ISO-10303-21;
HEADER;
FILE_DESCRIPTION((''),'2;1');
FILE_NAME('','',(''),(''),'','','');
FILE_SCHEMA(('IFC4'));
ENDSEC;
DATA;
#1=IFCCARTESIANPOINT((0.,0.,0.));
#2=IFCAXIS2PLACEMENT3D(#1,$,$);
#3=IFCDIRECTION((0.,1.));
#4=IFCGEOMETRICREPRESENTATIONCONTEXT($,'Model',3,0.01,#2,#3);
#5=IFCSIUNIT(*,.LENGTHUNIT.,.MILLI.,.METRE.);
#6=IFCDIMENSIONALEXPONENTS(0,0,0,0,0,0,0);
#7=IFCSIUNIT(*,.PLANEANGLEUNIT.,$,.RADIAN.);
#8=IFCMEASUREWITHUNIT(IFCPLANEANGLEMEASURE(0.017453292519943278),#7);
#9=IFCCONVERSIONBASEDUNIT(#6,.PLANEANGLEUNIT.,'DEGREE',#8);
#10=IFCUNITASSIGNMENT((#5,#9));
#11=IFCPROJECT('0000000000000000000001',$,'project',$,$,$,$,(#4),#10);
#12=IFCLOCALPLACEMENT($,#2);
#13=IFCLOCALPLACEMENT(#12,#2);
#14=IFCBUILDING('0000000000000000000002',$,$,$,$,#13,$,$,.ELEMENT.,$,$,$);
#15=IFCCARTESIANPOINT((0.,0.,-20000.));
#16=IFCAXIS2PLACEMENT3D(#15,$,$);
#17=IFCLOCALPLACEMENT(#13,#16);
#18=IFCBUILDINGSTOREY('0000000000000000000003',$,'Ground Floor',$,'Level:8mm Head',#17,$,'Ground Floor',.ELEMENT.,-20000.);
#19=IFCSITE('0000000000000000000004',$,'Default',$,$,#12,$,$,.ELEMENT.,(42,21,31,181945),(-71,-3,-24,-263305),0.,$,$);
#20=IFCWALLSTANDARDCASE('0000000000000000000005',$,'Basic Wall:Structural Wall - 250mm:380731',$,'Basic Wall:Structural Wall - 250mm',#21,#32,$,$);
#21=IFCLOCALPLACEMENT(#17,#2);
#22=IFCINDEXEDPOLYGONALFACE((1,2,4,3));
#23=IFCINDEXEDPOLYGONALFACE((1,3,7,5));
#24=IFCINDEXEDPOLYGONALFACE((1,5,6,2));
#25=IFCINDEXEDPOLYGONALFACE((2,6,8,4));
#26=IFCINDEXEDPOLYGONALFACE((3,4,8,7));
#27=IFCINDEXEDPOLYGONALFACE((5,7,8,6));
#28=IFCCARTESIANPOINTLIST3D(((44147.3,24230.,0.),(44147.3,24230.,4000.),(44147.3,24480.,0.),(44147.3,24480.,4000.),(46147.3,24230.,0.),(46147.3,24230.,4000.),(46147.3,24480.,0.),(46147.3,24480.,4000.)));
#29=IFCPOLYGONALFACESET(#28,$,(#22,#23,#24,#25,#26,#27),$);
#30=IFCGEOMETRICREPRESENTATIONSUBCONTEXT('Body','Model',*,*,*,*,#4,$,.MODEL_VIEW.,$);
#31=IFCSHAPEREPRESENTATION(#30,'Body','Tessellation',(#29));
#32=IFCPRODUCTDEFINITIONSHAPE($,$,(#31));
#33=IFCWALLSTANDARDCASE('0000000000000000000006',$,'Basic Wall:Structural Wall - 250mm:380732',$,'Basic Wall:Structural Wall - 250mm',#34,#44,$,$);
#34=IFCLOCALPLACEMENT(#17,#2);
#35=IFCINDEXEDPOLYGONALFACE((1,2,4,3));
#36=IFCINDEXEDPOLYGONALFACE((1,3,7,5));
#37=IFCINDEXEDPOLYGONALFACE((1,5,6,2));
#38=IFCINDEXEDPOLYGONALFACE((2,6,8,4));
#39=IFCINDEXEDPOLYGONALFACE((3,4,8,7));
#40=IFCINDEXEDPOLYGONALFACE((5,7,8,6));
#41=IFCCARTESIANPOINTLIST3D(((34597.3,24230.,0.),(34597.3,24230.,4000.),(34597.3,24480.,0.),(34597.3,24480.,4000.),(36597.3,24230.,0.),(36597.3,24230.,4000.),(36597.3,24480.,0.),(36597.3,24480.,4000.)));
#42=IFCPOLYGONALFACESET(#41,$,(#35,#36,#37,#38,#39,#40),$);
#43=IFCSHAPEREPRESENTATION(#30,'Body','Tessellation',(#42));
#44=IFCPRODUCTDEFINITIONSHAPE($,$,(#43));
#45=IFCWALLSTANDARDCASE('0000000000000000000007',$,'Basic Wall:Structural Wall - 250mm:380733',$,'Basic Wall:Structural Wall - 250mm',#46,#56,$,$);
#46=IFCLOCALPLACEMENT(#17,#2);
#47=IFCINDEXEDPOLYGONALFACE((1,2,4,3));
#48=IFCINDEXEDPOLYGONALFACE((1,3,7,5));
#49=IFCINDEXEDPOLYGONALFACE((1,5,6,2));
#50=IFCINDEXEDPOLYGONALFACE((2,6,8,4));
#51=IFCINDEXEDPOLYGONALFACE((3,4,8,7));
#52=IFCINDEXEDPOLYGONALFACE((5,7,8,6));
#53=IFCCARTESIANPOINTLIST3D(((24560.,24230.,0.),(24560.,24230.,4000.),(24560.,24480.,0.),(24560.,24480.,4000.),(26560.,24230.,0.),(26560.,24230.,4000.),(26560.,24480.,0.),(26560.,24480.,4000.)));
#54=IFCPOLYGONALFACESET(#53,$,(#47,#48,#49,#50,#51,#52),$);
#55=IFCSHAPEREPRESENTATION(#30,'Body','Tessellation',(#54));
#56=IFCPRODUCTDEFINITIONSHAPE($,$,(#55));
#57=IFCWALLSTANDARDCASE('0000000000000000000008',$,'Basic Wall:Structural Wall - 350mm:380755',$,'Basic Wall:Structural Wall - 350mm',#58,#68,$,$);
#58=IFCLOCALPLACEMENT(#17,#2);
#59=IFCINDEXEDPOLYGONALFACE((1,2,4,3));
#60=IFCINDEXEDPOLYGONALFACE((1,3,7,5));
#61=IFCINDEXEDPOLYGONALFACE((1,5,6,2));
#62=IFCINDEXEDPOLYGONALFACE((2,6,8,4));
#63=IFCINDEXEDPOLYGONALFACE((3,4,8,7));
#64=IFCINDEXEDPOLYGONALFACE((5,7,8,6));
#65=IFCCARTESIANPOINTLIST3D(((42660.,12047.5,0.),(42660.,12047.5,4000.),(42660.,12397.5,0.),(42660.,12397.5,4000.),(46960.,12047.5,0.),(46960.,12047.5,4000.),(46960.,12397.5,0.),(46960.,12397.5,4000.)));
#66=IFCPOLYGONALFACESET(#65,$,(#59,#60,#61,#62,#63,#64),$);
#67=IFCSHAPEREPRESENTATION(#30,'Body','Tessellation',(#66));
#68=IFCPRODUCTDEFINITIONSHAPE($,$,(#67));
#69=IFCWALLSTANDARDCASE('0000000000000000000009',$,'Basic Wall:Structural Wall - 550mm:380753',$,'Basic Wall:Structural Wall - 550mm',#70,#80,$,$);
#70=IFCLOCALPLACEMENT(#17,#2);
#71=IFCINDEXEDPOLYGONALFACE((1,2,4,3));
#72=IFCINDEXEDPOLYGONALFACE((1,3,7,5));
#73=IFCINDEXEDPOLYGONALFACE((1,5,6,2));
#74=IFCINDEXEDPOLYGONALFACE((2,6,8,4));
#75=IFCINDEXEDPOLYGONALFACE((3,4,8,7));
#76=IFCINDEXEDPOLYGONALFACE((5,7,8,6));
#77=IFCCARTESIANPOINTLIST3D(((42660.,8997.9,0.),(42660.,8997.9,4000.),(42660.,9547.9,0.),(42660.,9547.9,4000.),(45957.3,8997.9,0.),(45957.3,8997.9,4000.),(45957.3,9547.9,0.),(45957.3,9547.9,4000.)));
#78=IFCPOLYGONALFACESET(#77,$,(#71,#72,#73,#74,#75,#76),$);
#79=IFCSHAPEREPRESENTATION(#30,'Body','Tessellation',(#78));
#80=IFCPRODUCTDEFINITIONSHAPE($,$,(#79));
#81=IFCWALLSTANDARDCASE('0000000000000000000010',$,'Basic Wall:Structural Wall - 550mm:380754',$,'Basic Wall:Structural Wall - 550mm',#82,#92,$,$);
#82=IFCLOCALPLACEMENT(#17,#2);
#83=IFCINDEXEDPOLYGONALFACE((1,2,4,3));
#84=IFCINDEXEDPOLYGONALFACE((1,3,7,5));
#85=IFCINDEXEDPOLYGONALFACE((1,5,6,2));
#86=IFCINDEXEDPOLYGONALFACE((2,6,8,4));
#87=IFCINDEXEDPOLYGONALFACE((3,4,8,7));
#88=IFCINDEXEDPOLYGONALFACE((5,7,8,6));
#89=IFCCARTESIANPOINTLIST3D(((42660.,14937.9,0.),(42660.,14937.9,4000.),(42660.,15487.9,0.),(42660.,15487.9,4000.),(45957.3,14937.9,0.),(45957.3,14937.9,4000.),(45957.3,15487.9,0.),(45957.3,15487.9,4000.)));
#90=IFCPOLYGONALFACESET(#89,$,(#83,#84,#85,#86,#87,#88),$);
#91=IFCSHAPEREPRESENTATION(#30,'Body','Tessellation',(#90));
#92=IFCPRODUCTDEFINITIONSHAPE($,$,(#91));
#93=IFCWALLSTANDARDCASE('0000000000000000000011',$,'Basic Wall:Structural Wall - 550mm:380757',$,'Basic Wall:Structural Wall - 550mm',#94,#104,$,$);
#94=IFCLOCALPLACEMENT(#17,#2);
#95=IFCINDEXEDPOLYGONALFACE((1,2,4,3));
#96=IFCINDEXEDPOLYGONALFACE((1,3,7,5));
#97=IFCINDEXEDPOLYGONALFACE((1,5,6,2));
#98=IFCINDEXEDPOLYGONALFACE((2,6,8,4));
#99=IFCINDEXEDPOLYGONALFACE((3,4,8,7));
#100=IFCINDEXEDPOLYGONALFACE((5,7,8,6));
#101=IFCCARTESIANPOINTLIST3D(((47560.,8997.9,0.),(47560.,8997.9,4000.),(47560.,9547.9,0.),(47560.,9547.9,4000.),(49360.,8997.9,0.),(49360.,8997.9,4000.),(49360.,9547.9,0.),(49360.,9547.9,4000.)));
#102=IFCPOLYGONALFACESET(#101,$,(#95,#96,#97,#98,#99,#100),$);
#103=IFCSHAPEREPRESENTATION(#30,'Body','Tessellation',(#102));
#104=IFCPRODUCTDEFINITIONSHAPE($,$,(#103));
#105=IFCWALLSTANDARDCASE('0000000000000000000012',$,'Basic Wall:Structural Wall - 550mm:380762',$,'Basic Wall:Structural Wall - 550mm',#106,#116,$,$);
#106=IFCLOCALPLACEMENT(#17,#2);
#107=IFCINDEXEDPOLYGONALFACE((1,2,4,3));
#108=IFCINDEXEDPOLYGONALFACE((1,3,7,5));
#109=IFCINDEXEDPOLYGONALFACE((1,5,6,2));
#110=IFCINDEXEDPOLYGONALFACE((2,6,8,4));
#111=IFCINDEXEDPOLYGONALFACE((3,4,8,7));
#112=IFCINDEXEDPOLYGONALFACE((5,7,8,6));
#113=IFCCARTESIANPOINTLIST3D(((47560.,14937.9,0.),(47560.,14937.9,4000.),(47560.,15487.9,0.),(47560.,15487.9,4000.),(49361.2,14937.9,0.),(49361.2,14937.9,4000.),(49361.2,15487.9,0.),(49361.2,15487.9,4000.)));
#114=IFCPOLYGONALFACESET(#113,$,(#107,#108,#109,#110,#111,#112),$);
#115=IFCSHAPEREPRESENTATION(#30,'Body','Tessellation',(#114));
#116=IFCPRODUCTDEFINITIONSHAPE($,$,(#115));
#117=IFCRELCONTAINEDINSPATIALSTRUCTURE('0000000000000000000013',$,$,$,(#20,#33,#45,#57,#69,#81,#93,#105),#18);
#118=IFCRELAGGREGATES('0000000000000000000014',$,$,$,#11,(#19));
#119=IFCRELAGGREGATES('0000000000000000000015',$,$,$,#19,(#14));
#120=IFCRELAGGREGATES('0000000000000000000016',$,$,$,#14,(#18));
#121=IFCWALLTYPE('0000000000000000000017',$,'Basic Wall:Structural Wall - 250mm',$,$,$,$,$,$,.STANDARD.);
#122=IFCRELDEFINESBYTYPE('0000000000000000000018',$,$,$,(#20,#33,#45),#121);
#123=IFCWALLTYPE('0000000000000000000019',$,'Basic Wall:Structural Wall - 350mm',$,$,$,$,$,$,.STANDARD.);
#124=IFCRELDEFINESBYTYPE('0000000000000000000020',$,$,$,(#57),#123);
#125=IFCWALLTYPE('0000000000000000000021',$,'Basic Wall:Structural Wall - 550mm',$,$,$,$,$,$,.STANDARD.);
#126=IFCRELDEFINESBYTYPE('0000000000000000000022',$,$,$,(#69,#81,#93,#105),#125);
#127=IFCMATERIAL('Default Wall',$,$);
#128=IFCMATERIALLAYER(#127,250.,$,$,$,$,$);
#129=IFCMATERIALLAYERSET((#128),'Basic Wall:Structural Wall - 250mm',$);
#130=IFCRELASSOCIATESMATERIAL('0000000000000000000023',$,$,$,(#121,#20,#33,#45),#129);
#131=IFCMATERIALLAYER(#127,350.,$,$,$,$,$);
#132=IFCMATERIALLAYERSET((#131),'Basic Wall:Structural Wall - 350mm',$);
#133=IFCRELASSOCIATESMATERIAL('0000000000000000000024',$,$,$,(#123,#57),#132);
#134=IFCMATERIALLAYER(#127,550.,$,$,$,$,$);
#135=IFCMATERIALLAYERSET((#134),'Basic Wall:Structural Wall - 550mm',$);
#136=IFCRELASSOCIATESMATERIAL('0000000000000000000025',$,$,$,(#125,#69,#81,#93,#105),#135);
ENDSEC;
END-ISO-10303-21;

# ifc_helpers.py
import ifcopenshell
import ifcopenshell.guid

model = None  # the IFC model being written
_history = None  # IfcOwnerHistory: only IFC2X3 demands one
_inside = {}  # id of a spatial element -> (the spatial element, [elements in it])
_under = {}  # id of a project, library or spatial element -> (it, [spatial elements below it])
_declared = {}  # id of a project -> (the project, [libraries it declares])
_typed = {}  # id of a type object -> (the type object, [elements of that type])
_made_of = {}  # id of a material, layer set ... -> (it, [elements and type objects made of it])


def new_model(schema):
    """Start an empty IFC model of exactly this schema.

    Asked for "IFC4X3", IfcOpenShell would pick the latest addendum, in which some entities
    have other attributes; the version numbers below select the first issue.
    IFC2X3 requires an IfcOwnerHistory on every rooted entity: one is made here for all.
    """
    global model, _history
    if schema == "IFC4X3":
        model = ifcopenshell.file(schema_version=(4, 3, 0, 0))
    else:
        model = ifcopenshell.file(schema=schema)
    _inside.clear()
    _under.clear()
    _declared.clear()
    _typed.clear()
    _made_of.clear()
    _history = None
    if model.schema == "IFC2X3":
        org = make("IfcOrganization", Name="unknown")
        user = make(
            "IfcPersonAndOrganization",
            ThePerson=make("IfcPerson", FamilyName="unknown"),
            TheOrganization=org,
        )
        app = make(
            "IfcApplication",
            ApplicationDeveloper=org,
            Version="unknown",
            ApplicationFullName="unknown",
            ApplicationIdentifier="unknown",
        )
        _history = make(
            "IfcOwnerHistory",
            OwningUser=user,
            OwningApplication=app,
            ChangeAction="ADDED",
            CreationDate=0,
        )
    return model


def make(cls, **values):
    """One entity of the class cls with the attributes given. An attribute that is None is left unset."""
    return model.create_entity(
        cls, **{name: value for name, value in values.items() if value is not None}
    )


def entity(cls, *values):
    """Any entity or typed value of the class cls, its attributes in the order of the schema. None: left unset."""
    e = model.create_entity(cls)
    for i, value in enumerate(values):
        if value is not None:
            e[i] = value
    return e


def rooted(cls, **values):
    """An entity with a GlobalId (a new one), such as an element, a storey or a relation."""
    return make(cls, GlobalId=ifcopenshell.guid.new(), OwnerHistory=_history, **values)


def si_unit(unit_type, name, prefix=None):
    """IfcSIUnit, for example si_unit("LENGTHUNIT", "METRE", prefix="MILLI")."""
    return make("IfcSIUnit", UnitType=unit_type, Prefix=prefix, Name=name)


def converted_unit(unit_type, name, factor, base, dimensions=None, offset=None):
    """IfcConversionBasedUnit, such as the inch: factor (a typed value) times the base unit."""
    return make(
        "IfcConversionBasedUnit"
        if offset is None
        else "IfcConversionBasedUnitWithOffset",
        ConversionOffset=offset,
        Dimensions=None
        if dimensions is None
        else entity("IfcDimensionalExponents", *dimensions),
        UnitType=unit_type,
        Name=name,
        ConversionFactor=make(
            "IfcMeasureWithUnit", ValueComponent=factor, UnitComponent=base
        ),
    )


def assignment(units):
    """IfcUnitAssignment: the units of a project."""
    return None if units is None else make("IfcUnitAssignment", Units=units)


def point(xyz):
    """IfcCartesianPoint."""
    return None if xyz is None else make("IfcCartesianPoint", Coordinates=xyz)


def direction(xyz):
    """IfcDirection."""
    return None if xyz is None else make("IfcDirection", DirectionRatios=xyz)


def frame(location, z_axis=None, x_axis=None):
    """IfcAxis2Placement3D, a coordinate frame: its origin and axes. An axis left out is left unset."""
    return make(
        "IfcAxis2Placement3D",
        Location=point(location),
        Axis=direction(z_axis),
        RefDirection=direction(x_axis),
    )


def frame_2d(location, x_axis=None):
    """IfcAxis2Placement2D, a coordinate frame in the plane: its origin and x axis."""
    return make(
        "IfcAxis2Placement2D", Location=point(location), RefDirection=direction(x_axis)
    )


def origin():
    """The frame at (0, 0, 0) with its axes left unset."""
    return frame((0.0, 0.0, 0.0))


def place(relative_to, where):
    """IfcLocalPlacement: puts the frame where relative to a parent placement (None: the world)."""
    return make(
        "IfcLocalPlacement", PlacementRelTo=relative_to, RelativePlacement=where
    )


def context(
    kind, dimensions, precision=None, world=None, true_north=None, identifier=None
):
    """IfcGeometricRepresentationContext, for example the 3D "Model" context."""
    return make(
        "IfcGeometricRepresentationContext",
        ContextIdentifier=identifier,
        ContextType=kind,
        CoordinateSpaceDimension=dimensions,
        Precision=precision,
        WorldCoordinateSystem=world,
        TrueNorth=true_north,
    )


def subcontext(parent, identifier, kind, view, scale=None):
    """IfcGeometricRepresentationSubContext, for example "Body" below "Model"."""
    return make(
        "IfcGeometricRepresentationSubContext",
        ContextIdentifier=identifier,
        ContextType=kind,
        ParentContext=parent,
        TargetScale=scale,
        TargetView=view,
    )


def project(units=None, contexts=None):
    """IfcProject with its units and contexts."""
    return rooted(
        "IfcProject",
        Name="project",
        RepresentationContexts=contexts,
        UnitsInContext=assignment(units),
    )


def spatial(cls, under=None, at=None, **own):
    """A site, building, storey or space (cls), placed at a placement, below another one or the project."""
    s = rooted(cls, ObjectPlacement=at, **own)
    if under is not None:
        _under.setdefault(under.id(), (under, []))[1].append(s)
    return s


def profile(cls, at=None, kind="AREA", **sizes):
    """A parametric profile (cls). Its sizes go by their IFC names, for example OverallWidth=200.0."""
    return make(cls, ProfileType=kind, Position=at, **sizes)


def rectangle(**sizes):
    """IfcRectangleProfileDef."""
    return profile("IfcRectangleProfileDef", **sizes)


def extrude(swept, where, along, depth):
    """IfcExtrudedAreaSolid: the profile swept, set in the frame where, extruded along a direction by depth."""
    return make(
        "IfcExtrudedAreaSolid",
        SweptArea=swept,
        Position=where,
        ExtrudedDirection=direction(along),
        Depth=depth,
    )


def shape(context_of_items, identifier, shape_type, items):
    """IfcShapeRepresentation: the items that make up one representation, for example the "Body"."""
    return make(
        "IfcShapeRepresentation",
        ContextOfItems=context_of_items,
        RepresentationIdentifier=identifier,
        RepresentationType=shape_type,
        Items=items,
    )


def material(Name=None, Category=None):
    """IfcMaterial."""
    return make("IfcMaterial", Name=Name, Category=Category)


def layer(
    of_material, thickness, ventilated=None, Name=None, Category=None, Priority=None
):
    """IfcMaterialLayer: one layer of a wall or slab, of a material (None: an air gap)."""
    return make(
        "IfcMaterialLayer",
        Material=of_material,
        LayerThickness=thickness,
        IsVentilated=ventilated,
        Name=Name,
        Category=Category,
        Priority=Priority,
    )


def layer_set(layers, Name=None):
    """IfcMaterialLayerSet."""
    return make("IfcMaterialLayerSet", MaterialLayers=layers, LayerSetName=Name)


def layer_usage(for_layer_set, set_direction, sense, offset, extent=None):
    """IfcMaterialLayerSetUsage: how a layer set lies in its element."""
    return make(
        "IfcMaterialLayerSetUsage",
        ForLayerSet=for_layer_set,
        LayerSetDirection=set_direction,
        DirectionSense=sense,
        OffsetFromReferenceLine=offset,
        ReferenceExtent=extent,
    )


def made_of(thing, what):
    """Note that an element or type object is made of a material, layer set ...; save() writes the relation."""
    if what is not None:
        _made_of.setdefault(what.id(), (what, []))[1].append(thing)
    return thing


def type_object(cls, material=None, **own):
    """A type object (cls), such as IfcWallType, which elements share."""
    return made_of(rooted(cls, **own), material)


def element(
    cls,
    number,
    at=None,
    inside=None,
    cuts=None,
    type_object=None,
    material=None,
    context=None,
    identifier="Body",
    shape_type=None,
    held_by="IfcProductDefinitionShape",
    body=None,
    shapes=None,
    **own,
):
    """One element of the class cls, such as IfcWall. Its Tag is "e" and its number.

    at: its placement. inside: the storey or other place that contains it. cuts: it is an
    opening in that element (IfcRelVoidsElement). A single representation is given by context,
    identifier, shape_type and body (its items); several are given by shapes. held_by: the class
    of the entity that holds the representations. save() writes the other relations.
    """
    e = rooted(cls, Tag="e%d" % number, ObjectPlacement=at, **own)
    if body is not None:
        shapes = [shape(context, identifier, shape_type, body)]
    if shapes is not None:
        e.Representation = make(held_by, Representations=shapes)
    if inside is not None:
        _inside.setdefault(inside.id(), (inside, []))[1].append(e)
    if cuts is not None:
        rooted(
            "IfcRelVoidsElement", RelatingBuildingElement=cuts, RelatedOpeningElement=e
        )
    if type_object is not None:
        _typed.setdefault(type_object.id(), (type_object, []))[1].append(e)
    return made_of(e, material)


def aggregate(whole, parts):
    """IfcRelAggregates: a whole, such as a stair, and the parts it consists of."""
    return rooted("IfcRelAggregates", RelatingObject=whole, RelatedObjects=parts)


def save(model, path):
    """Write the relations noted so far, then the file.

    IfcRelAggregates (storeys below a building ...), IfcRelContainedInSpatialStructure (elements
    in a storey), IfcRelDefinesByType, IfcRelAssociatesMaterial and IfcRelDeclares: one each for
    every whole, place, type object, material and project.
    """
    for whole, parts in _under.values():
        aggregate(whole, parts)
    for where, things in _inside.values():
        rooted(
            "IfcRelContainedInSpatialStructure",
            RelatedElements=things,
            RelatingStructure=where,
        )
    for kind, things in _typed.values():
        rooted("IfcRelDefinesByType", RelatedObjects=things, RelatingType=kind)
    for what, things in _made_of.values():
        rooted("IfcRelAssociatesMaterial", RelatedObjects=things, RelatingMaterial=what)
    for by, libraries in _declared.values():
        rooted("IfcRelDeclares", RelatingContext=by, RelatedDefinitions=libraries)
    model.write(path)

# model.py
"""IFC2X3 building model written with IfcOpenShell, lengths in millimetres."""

from ifc_helpers import new_model, entity, si_unit, converted_unit, direction, frame, frame_2d, origin, place, context, subcontext, project, spatial, rectangle, extrude, material, layer, layer_set, layer_usage, type_object, element, save


model = new_model("IFC2X3")

# Units and contexts
model_context = context("Model", 3, precision=0.01, world=origin(), true_north=direction((0.0, 1.0)))
body_context = subcontext(model_context, "Body", "Model", "MODEL_VIEW")
ifc_project = project(units=[si_unit("LENGTHUNIT", "METRE", prefix="MILLI"), converted_unit("PLANEANGLEUNIT", "DEGREE", entity("IfcPlaneAngleMeasure", 0.017453292519943278), si_unit("PLANEANGLEUNIT", "RADIAN"), dimensions=[0, 0, 0, 0, 0, 0, 0])], contexts=[model_context])

# Site, building, storey
site_placement = place(None, origin())
site = spatial("IfcSite", under=ifc_project, at=site_placement, Name="Default", CompositionType="ELEMENT", RefLatitude=(42, 21, 31, 181945), RefLongitude=(-71, -3, -24, -263305), RefElevation=0.0)
building_placement = place(site_placement, origin())
building = spatial("IfcBuilding", under=site, at=building_placement, CompositionType="ELEMENT")
storey_placement = place(building_placement, frame((0.0, 0.0, -20000.0)))
storey = spatial("IfcBuildingStorey", under=building, at=storey_placement, Name="Ground Floor", ObjectType="Level:8mm Head", LongName="Ground Floor", CompositionType="ELEMENT", Elevation=-20000.0)

# Walls
ifc_material_1 = material(Name="Default Wall")
ifc_layer_1 = layer(ifc_material_1, 250.0)
ifc_layer_set_1 = layer_set([ifc_layer_1], Name="Basic Wall:Structural Wall - 250mm")
wall_type_1 = type_object("IfcWallType", Name="Basic Wall:Structural Wall - 250mm", PredefinedType="STANDARD", material=ifc_layer_set_1)
ifc_layer_usage_1 = layer_usage(ifc_layer_set_1, "AXIS2", "NEGATIVE", 125.0)
wall_1_placement = place(storey_placement, frame((44147.3, 24355.0, 0.0)))
element("IfcWallStandardCase", 1, at=wall_1_placement, inside=storey, type_object=wall_type_1, material=ifc_layer_usage_1, Name="Basic Wall:Structural Wall - 250mm:380731", ObjectType="Basic Wall:Structural Wall - 250mm", context=body_context, shape_type="SweptSolid", body=[
    extrude(rectangle(XDim=2000.0, YDim=250.0, at=frame_2d((1000.0, 0.0), x_axis=(-1.0, 0.0))), origin(), (0.0, 0.0, 1.0), 4000.0),
])
ifc_layer_usage_2 = layer_usage(ifc_layer_set_1, "AXIS2", "NEGATIVE", 125.0)
wall_2_placement = place(storey_placement, frame((34597.3, 24355.0, 0.0)))
element("IfcWallStandardCase", 2, at=wall_2_placement, inside=storey, type_object=wall_type_1, material=ifc_layer_usage_2, Name="Basic Wall:Structural Wall - 250mm:380732", ObjectType="Basic Wall:Structural Wall - 250mm", context=body_context, shape_type="SweptSolid", body=[
    extrude(rectangle(XDim=2000.0, YDim=250.0, at=frame_2d((1000.0, 0.0), x_axis=(-1.0, 0.0))), origin(), (0.0, 0.0, 1.0), 4000.0),
])
ifc_layer_usage_3 = layer_usage(ifc_layer_set_1, "AXIS2", "NEGATIVE", 125.0)
wall_3_placement = place(storey_placement, frame((24560.0, 24355.0, 0.0)))
element("IfcWallStandardCase", 3, at=wall_3_placement, inside=storey, type_object=wall_type_1, material=ifc_layer_usage_3, Name="Basic Wall:Structural Wall - 250mm:380733", ObjectType="Basic Wall:Structural Wall - 250mm", context=body_context, shape_type="SweptSolid", body=[
    extrude(rectangle(XDim=2000.0, YDim=250.0, at=frame_2d((1000.0, 0.0), x_axis=(-1.0, 0.0))), origin(), (0.0, 0.0, 1.0), 4000.0),
])
ifc_layer_2 = layer(ifc_material_1, 350.0)
ifc_layer_set_2 = layer_set([ifc_layer_2], Name="Basic Wall:Structural Wall - 350mm")
ifc_layer_usage_4 = layer_usage(ifc_layer_set_2, "AXIS2", "NEGATIVE", 175.0)
wall_type_2 = type_object("IfcWallType", Name="Basic Wall:Structural Wall - 350mm", PredefinedType="STANDARD", material=ifc_layer_set_2)
wall_4_placement = place(storey_placement, frame((42660.0, 12222.5, 0.0)))
element("IfcWallStandardCase", 4, at=wall_4_placement, inside=storey, type_object=wall_type_2, material=ifc_layer_usage_4, Name="Basic Wall:Structural Wall - 350mm:380755", ObjectType="Basic Wall:Structural Wall - 350mm", context=body_context, shape_type="SweptSolid", body=[
    extrude(rectangle(XDim=4300.0, YDim=350.0, at=frame_2d((2150.0, 0.0), x_axis=(-1.0, 0.0))), origin(), (0.0, 0.0, 1.0), 4000.0),
])
ifc_layer_3 = layer(ifc_material_1, 550.0)
ifc_layer_set_3 = layer_set([ifc_layer_3], Name="Basic Wall:Structural Wall - 550mm")
ifc_layer_usage_5 = layer_usage(ifc_layer_set_3, "AXIS2", "NEGATIVE", 275.0)
wall_type_3 = type_object("IfcWallType", Name="Basic Wall:Structural Wall - 550mm", PredefinedType="STANDARD", material=ifc_layer_set_3)
wall_5_placement = place(storey_placement, frame((42660.0, 9272.9, 0.0)))
element("IfcWallStandardCase", 5, at=wall_5_placement, inside=storey, type_object=wall_type_3, material=ifc_layer_usage_5, Name="Basic Wall:Structural Wall - 550mm:380753", ObjectType="Basic Wall:Structural Wall - 550mm", context=body_context, shape_type="SweptSolid", body=[
    extrude(rectangle(XDim=3297.3, YDim=550.0, at=frame_2d((1648.6, 0.0), x_axis=(-1.0, 0.0))), origin(), (0.0, 0.0, 1.0), 4000.0),
])
ifc_layer_usage_6 = layer_usage(ifc_layer_set_3, "AXIS2", "NEGATIVE", 275.0)
wall_6_placement = place(storey_placement, frame((45957.3, 15212.9, 0.0), z_axis=(0.0, 0.0, 1.0), x_axis=(-1.0, 0.0, 0.0)))
element("IfcWallStandardCase", 6, at=wall_6_placement, inside=storey, type_object=wall_type_3, material=ifc_layer_usage_6, Name="Basic Wall:Structural Wall - 550mm:380754", ObjectType="Basic Wall:Structural Wall - 550mm", context=body_context, shape_type="SweptSolid", body=[
    extrude(rectangle(XDim=3297.3, YDim=550.0, at=frame_2d((1648.6, 0.0), x_axis=(-1.0, 0.0))), origin(), (0.0, 0.0, 1.0), 4000.0),
])
ifc_layer_usage_7 = layer_usage(ifc_layer_set_3, "AXIS2", "NEGATIVE", 275.0)
wall_7_placement = place(storey_placement, frame((47560.0, 9272.9, 0.0)))
element("IfcWallStandardCase", 7, at=wall_7_placement, inside=storey, type_object=wall_type_3, material=ifc_layer_usage_7, Name="Basic Wall:Structural Wall - 550mm:380757", ObjectType="Basic Wall:Structural Wall - 550mm", context=body_context, shape_type="SweptSolid", body=[
    extrude(rectangle(XDim=1800.0, YDim=550.0, at=frame_2d((900.0, 0.0), x_axis=(-1.0, 0.0))), origin(), (0.0, 0.0, 1.0), 4000.0),
])
ifc_layer_usage_8 = layer_usage(ifc_layer_set_3, "AXIS2", "NEGATIVE", 275.0)
wall_8_placement = place(storey_placement, frame((49361.2, 15212.9, 0.0), z_axis=(0.0, 0.0, 1.0), x_axis=(-1.0, 0.0, 0.0)))
element("IfcWallStandardCase", 8, at=wall_8_placement, inside=storey, type_object=wall_type_3, material=ifc_layer_usage_8, Name="Basic Wall:Structural Wall - 550mm:380762", ObjectType="Basic Wall:Structural Wall - 550mm", context=body_context, shape_type="SweptSolid", body=[
    extrude(rectangle(XDim=1801.2, YDim=550.0, at=frame_2d((900.6, 0.0), x_axis=(-1.0, 0.0))), origin(), (0.0, 0.0, 1.0), 4000.0),
])

save(model, "model.ifc")
